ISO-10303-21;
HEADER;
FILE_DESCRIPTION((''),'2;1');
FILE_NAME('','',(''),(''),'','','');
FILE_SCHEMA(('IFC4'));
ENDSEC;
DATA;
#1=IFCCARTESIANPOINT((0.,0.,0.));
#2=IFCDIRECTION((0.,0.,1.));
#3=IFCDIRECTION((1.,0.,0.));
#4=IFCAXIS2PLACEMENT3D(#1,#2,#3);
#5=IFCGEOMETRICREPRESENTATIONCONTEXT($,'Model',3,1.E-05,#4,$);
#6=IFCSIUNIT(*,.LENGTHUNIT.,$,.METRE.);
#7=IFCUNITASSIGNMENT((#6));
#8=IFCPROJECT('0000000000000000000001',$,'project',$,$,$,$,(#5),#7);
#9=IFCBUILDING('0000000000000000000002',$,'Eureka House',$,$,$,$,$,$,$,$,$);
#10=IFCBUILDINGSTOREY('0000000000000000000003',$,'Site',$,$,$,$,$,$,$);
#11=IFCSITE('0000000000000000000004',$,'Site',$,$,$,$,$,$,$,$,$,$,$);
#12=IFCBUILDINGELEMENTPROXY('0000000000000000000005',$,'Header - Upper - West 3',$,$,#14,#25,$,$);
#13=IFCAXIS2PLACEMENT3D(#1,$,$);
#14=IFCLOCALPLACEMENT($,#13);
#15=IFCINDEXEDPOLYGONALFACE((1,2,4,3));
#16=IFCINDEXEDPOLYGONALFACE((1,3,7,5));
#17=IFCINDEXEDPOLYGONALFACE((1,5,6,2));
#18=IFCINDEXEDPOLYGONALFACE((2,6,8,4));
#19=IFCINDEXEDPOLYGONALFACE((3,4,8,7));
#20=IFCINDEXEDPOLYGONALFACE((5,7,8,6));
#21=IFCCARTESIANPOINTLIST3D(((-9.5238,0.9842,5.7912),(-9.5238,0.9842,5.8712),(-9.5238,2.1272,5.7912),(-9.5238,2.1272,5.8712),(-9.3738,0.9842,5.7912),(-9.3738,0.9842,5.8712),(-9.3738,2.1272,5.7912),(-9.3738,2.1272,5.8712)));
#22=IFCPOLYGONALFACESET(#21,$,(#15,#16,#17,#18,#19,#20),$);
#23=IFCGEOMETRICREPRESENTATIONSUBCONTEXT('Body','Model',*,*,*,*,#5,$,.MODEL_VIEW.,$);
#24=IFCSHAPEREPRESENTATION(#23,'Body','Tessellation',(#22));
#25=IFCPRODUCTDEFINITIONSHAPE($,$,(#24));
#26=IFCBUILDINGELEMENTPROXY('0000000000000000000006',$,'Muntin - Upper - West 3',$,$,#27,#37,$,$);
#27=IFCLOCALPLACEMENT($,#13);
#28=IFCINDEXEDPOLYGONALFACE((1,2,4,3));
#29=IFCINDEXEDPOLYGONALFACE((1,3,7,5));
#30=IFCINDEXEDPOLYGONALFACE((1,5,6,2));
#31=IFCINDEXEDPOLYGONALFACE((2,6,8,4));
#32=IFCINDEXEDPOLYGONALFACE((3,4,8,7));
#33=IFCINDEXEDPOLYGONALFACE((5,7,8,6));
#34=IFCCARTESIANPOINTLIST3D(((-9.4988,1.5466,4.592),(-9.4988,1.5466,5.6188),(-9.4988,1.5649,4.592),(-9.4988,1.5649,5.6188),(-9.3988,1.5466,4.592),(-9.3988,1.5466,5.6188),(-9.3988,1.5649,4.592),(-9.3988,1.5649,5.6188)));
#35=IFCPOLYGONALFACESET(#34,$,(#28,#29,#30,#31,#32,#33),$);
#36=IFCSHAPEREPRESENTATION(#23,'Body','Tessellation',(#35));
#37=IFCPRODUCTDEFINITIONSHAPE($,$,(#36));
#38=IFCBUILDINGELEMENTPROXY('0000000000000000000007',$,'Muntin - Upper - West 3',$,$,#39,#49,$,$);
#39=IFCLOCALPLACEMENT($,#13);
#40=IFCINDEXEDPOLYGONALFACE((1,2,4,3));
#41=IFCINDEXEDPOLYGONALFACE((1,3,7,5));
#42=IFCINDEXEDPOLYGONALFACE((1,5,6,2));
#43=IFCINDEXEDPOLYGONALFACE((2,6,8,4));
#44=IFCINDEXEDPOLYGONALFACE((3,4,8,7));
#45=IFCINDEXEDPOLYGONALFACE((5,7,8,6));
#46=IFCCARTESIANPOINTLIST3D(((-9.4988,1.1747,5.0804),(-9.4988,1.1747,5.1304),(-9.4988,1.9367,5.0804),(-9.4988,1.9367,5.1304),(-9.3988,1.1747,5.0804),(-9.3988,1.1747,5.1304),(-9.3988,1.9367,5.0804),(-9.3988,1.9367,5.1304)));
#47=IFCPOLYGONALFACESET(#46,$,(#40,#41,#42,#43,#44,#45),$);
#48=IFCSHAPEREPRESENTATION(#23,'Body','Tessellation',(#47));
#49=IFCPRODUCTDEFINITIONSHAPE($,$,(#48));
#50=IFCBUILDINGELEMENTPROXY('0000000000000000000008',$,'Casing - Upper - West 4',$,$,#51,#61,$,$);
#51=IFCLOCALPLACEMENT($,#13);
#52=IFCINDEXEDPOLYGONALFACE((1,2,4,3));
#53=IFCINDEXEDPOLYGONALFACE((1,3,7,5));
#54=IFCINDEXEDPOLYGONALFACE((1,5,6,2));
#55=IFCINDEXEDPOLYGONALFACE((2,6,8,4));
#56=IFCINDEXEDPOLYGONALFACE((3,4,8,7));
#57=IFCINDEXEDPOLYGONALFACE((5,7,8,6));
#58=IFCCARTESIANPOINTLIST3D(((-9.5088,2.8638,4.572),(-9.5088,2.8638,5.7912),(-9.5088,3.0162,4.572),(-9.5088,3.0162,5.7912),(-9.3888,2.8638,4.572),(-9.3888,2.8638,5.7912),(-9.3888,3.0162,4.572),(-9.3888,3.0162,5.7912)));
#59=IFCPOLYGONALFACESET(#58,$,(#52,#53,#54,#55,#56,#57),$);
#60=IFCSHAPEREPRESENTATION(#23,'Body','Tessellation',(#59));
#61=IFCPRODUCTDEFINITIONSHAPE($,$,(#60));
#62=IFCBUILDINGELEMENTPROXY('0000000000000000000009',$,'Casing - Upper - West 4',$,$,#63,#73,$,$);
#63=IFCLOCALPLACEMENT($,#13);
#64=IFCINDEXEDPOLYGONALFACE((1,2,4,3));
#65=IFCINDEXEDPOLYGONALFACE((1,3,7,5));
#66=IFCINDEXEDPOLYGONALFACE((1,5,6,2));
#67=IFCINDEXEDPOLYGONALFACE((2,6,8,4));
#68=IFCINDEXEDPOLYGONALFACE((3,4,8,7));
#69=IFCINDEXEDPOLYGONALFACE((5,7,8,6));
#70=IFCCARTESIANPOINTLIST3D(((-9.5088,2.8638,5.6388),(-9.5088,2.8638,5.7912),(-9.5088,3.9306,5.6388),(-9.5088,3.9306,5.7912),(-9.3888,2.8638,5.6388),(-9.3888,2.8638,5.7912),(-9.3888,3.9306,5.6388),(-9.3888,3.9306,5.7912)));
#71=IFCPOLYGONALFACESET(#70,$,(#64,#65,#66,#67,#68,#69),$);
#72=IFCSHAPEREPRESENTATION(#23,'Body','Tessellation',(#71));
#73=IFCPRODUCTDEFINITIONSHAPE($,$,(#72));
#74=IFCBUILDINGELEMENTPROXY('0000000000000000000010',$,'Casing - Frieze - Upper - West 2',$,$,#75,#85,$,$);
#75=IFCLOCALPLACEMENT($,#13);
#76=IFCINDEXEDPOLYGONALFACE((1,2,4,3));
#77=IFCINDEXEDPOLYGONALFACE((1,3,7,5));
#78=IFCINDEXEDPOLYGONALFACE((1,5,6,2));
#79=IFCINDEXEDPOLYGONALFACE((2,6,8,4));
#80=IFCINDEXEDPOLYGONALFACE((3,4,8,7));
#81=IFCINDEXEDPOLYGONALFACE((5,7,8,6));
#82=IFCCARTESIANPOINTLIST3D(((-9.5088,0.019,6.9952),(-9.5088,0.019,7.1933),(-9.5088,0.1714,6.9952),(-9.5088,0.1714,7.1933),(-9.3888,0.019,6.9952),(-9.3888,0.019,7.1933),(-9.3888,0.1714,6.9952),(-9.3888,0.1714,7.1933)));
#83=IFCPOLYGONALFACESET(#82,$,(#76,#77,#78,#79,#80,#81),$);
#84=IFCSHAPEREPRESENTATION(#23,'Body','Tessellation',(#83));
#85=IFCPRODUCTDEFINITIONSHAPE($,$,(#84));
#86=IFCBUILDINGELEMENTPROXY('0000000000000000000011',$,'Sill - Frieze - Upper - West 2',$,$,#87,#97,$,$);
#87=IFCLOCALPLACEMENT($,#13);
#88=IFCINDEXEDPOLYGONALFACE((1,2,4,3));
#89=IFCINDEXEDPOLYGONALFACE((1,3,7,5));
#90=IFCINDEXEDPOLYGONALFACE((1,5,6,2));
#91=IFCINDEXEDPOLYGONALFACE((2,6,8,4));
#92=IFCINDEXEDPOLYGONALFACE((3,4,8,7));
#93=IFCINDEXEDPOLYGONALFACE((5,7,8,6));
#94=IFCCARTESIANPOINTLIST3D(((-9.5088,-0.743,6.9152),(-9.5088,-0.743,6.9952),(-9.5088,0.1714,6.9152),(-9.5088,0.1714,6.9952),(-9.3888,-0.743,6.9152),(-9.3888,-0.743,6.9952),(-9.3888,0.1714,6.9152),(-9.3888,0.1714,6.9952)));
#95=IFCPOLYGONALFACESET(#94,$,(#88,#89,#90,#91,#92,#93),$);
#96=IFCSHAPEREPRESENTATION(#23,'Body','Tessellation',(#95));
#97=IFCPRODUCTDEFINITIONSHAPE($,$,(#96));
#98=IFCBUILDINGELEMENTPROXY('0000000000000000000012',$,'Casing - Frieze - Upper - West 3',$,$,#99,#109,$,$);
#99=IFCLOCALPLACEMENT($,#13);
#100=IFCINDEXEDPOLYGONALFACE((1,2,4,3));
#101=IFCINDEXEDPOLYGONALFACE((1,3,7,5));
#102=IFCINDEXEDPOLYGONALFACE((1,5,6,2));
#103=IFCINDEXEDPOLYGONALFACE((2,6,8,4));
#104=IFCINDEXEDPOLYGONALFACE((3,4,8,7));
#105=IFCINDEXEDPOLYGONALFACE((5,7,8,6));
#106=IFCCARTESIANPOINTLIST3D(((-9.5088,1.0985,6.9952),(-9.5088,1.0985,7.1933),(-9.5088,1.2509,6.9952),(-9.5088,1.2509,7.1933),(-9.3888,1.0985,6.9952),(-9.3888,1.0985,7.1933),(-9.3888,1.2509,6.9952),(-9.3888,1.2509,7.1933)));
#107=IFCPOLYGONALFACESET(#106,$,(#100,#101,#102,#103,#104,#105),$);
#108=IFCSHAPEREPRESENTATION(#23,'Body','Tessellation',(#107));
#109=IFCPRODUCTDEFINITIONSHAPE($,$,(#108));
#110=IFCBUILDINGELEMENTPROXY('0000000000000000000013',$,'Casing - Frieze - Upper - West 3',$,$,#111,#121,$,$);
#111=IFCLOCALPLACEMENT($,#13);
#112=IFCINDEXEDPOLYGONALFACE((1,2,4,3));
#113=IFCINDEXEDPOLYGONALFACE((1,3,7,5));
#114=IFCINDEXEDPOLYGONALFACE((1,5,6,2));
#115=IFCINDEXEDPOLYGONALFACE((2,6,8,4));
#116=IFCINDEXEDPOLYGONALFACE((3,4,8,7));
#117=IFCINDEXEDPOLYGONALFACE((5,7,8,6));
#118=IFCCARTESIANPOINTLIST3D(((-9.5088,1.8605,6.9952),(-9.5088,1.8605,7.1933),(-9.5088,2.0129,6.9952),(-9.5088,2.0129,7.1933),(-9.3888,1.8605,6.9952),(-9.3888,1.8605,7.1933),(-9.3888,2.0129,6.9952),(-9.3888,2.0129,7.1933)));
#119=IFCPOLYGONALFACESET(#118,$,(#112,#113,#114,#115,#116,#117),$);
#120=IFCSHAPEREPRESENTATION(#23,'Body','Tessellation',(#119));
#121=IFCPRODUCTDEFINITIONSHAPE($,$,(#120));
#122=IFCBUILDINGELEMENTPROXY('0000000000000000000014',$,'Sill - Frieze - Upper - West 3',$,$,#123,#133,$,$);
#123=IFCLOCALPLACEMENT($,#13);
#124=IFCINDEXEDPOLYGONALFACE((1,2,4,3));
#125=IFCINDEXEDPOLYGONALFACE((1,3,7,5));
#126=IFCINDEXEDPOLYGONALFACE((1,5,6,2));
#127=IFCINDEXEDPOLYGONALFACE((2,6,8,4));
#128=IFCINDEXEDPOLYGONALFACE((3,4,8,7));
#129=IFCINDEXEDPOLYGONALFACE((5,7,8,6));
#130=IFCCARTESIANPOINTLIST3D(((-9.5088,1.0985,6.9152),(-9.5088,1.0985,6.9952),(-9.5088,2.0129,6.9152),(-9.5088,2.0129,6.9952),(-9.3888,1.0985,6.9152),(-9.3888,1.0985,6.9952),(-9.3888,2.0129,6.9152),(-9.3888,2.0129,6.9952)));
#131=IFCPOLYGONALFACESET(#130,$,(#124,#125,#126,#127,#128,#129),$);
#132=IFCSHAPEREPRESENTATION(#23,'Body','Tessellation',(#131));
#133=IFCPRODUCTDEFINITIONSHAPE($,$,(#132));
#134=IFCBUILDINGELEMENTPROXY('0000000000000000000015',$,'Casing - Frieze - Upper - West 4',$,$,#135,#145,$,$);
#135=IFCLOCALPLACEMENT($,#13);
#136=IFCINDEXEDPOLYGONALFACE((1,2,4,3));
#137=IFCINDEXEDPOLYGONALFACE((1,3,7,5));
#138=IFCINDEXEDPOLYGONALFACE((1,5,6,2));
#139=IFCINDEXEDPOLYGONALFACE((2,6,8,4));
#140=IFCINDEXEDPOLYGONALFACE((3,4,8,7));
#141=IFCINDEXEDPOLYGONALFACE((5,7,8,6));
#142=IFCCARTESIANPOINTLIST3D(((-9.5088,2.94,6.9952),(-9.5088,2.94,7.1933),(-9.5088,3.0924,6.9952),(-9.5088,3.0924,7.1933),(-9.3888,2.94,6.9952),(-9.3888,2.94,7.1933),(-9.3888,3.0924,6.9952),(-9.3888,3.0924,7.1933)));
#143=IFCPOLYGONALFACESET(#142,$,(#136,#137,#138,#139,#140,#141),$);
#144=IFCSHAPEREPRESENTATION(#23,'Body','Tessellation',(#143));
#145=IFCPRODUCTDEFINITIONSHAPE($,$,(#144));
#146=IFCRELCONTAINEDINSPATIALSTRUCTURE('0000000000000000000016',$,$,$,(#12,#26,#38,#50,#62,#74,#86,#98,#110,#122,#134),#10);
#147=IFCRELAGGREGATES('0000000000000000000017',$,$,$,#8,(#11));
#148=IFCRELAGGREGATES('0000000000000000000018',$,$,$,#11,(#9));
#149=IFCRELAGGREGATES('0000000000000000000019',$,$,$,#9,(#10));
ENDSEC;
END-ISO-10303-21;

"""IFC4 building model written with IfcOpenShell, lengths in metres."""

from ifc_helpers import new_model, si_unit, frame, origin, origin_with_axes, origin_2d, place, context, subcontext, project, spatial, rectangle, extrude, element, save


model = new_model("IFC4")

# Units and contexts
model_context = context("Model", 3, precision=1e-05, world=origin_with_axes())
body_context = subcontext(model_context, "Body", "Model", "MODEL_VIEW")
ifc_project = project(units=[si_unit("LENGTHUNIT", "METRE")], contexts=[model_context])

# Site, building, storey
site = spatial("IfcSite", under=ifc_project, Name="Site")
building = spatial("IfcBuilding", under=site, Name="Eureka House")
storey = spatial("IfcBuildingStorey", under=building, Name="Site")

# Building element proxies
proxy_1_placement = place(None, frame((-9.4488, 1.5557, 5.7912), z_axis=(0.0, 0.0, 1.0), x_axis=(1.0, 0.0, 0.0)))
element("IfcBuildingElementProxy", 1, at=proxy_1_placement, inside=storey, Name="Header - Upper - West 3", context=body_context, shape_type="SweptSolid", body=[
    extrude(rectangle(XDim=0.15, YDim=1.143, at=origin_2d()), origin(), (0.0, 0.0, 1.0), 0.08),
])
proxy_2_placement = place(None, frame((-9.4488, 1.5557, 4.592), z_axis=(0.0, 0.0, 1.0), x_axis=(1.0, 0.0, 0.0)))
element("IfcBuildingElementProxy", 2, at=proxy_2_placement, inside=storey, Name="Muntin - Upper - West 3", context=body_context, shape_type="SweptSolid", body=[
    extrude(rectangle(XDim=0.1, YDim=0.0183, at=origin_2d()), origin(), (0.0, 0.0, 1.0), 1.0268),
])
proxy_3_placement = place(None, frame((-9.4488, 1.5557, 5.0804), z_axis=(0.0, 0.0, 1.0), x_axis=(1.0, 0.0, 0.0)))
element("IfcBuildingElementProxy", 3, at=proxy_3_placement, inside=storey, Name="Muntin - Upper - West 3", context=body_context, shape_type="SweptSolid", body=[
    extrude(rectangle(XDim=0.1, YDim=0.762, at=origin_2d()), origin(), (0.0, 0.0, 1.0), 0.05),
])
proxy_4_placement = place(None, frame((-9.4488, 2.94, 4.572), z_axis=(0.0, 0.0, 1.0), x_axis=(1.0, 0.0, 0.0)))
element("IfcBuildingElementProxy", 4, at=proxy_4_placement, inside=storey, Name="Casing - Upper - West 4", context=body_context, shape_type="SweptSolid", body=[
    extrude(rectangle(XDim=0.12, YDim=0.1524, at=origin_2d()), origin(), (0.0, 0.0, 1.0), 1.2192),
])
proxy_5_placement = place(None, frame((-9.4488, 3.3972, 5.6388), z_axis=(0.0, 0.0, 1.0), x_axis=(1.0, 0.0, 0.0)))
element("IfcBuildingElementProxy", 5, at=proxy_5_placement, inside=storey, Name="Casing - Upper - West 4", context=body_context, shape_type="SweptSolid", body=[
    extrude(rectangle(XDim=0.12, YDim=1.0668, at=origin_2d()), origin(), (0.0, 0.0, 1.0), 0.1524),
])
proxy_6_placement = place(None, frame((-9.4488, 0.0952, 6.9952), z_axis=(0.0, 0.0, 1.0), x_axis=(1.0, 0.0, 0.0)))
element("IfcBuildingElementProxy", 6, at=proxy_6_placement, inside=storey, Name="Casing - Frieze - Upper - West 2", context=body_context, shape_type="SweptSolid", body=[
    extrude(rectangle(XDim=0.12, YDim=0.1524, at=origin_2d()), origin(), (0.0, 0.0, 1.0), 0.1981),
])
proxy_7_placement = place(None, frame((-9.4488, -0.2858, 6.9152), z_axis=(0.0, 0.0, 1.0), x_axis=(1.0, 0.0, 0.0)))
element("IfcBuildingElementProxy", 7, at=proxy_7_placement, inside=storey, Name="Sill - Frieze - Upper - West 2", context=body_context, shape_type="SweptSolid", body=[
    extrude(rectangle(XDim=0.12, YDim=0.9144, at=origin_2d()), origin(), (0.0, 0.0, 1.0), 0.08),
])
for number, where, z_axis, x_axis, name in (
    (8, (-9.4488, 1.1747, 6.9952), (0.0, 0.0, 1.0), (1.0, 0.0, 0.0), "Casing - Frieze - Upper - West 3"),
    (9, (-9.4488, 1.9367, 6.9952), (0.0, 0.0, 1.0), (1.0, 0.0, 0.0), "Casing - Frieze - Upper - West 3"),
):
    element("IfcBuildingElementProxy", number, at=place(None, frame(where, z_axis=z_axis, x_axis=x_axis)), inside=storey, Name=name, context=body_context, shape_type="SweptSolid", body=[
        extrude(rectangle(XDim=0.12, YDim=0.1524, at=origin_2d()), origin(), (0.0, 0.0, 1.0), 0.1981),
    ])
proxy_8_placement = place(None, frame((-9.4488, 1.5557, 6.9152), z_axis=(0.0, 0.0, 1.0), x_axis=(1.0, 0.0, 0.0)))
element("IfcBuildingElementProxy", 10, at=proxy_8_placement, inside=storey, Name="Sill - Frieze - Upper - West 3", context=body_context, shape_type="SweptSolid", body=[
    extrude(rectangle(XDim=0.12, YDim=0.9144, at=origin_2d()), origin(), (0.0, 0.0, 1.0), 0.08),
])
proxy_9_placement = place(None, frame((-9.4488, 3.0162, 6.9952), z_axis=(0.0, 0.0, 1.0), x_axis=(1.0, 0.0, 0.0)))
element("IfcBuildingElementProxy", 11, at=proxy_9_placement, inside=storey, Name="Casing - Frieze - Upper - West 4", context=body_context, shape_type="SweptSolid", body=[
    extrude(rectangle(XDim=0.12, YDim=0.1524, at=origin_2d()), origin(), (0.0, 0.0, 1.0), 0.1981),
])

save(model, "model.ifc")
